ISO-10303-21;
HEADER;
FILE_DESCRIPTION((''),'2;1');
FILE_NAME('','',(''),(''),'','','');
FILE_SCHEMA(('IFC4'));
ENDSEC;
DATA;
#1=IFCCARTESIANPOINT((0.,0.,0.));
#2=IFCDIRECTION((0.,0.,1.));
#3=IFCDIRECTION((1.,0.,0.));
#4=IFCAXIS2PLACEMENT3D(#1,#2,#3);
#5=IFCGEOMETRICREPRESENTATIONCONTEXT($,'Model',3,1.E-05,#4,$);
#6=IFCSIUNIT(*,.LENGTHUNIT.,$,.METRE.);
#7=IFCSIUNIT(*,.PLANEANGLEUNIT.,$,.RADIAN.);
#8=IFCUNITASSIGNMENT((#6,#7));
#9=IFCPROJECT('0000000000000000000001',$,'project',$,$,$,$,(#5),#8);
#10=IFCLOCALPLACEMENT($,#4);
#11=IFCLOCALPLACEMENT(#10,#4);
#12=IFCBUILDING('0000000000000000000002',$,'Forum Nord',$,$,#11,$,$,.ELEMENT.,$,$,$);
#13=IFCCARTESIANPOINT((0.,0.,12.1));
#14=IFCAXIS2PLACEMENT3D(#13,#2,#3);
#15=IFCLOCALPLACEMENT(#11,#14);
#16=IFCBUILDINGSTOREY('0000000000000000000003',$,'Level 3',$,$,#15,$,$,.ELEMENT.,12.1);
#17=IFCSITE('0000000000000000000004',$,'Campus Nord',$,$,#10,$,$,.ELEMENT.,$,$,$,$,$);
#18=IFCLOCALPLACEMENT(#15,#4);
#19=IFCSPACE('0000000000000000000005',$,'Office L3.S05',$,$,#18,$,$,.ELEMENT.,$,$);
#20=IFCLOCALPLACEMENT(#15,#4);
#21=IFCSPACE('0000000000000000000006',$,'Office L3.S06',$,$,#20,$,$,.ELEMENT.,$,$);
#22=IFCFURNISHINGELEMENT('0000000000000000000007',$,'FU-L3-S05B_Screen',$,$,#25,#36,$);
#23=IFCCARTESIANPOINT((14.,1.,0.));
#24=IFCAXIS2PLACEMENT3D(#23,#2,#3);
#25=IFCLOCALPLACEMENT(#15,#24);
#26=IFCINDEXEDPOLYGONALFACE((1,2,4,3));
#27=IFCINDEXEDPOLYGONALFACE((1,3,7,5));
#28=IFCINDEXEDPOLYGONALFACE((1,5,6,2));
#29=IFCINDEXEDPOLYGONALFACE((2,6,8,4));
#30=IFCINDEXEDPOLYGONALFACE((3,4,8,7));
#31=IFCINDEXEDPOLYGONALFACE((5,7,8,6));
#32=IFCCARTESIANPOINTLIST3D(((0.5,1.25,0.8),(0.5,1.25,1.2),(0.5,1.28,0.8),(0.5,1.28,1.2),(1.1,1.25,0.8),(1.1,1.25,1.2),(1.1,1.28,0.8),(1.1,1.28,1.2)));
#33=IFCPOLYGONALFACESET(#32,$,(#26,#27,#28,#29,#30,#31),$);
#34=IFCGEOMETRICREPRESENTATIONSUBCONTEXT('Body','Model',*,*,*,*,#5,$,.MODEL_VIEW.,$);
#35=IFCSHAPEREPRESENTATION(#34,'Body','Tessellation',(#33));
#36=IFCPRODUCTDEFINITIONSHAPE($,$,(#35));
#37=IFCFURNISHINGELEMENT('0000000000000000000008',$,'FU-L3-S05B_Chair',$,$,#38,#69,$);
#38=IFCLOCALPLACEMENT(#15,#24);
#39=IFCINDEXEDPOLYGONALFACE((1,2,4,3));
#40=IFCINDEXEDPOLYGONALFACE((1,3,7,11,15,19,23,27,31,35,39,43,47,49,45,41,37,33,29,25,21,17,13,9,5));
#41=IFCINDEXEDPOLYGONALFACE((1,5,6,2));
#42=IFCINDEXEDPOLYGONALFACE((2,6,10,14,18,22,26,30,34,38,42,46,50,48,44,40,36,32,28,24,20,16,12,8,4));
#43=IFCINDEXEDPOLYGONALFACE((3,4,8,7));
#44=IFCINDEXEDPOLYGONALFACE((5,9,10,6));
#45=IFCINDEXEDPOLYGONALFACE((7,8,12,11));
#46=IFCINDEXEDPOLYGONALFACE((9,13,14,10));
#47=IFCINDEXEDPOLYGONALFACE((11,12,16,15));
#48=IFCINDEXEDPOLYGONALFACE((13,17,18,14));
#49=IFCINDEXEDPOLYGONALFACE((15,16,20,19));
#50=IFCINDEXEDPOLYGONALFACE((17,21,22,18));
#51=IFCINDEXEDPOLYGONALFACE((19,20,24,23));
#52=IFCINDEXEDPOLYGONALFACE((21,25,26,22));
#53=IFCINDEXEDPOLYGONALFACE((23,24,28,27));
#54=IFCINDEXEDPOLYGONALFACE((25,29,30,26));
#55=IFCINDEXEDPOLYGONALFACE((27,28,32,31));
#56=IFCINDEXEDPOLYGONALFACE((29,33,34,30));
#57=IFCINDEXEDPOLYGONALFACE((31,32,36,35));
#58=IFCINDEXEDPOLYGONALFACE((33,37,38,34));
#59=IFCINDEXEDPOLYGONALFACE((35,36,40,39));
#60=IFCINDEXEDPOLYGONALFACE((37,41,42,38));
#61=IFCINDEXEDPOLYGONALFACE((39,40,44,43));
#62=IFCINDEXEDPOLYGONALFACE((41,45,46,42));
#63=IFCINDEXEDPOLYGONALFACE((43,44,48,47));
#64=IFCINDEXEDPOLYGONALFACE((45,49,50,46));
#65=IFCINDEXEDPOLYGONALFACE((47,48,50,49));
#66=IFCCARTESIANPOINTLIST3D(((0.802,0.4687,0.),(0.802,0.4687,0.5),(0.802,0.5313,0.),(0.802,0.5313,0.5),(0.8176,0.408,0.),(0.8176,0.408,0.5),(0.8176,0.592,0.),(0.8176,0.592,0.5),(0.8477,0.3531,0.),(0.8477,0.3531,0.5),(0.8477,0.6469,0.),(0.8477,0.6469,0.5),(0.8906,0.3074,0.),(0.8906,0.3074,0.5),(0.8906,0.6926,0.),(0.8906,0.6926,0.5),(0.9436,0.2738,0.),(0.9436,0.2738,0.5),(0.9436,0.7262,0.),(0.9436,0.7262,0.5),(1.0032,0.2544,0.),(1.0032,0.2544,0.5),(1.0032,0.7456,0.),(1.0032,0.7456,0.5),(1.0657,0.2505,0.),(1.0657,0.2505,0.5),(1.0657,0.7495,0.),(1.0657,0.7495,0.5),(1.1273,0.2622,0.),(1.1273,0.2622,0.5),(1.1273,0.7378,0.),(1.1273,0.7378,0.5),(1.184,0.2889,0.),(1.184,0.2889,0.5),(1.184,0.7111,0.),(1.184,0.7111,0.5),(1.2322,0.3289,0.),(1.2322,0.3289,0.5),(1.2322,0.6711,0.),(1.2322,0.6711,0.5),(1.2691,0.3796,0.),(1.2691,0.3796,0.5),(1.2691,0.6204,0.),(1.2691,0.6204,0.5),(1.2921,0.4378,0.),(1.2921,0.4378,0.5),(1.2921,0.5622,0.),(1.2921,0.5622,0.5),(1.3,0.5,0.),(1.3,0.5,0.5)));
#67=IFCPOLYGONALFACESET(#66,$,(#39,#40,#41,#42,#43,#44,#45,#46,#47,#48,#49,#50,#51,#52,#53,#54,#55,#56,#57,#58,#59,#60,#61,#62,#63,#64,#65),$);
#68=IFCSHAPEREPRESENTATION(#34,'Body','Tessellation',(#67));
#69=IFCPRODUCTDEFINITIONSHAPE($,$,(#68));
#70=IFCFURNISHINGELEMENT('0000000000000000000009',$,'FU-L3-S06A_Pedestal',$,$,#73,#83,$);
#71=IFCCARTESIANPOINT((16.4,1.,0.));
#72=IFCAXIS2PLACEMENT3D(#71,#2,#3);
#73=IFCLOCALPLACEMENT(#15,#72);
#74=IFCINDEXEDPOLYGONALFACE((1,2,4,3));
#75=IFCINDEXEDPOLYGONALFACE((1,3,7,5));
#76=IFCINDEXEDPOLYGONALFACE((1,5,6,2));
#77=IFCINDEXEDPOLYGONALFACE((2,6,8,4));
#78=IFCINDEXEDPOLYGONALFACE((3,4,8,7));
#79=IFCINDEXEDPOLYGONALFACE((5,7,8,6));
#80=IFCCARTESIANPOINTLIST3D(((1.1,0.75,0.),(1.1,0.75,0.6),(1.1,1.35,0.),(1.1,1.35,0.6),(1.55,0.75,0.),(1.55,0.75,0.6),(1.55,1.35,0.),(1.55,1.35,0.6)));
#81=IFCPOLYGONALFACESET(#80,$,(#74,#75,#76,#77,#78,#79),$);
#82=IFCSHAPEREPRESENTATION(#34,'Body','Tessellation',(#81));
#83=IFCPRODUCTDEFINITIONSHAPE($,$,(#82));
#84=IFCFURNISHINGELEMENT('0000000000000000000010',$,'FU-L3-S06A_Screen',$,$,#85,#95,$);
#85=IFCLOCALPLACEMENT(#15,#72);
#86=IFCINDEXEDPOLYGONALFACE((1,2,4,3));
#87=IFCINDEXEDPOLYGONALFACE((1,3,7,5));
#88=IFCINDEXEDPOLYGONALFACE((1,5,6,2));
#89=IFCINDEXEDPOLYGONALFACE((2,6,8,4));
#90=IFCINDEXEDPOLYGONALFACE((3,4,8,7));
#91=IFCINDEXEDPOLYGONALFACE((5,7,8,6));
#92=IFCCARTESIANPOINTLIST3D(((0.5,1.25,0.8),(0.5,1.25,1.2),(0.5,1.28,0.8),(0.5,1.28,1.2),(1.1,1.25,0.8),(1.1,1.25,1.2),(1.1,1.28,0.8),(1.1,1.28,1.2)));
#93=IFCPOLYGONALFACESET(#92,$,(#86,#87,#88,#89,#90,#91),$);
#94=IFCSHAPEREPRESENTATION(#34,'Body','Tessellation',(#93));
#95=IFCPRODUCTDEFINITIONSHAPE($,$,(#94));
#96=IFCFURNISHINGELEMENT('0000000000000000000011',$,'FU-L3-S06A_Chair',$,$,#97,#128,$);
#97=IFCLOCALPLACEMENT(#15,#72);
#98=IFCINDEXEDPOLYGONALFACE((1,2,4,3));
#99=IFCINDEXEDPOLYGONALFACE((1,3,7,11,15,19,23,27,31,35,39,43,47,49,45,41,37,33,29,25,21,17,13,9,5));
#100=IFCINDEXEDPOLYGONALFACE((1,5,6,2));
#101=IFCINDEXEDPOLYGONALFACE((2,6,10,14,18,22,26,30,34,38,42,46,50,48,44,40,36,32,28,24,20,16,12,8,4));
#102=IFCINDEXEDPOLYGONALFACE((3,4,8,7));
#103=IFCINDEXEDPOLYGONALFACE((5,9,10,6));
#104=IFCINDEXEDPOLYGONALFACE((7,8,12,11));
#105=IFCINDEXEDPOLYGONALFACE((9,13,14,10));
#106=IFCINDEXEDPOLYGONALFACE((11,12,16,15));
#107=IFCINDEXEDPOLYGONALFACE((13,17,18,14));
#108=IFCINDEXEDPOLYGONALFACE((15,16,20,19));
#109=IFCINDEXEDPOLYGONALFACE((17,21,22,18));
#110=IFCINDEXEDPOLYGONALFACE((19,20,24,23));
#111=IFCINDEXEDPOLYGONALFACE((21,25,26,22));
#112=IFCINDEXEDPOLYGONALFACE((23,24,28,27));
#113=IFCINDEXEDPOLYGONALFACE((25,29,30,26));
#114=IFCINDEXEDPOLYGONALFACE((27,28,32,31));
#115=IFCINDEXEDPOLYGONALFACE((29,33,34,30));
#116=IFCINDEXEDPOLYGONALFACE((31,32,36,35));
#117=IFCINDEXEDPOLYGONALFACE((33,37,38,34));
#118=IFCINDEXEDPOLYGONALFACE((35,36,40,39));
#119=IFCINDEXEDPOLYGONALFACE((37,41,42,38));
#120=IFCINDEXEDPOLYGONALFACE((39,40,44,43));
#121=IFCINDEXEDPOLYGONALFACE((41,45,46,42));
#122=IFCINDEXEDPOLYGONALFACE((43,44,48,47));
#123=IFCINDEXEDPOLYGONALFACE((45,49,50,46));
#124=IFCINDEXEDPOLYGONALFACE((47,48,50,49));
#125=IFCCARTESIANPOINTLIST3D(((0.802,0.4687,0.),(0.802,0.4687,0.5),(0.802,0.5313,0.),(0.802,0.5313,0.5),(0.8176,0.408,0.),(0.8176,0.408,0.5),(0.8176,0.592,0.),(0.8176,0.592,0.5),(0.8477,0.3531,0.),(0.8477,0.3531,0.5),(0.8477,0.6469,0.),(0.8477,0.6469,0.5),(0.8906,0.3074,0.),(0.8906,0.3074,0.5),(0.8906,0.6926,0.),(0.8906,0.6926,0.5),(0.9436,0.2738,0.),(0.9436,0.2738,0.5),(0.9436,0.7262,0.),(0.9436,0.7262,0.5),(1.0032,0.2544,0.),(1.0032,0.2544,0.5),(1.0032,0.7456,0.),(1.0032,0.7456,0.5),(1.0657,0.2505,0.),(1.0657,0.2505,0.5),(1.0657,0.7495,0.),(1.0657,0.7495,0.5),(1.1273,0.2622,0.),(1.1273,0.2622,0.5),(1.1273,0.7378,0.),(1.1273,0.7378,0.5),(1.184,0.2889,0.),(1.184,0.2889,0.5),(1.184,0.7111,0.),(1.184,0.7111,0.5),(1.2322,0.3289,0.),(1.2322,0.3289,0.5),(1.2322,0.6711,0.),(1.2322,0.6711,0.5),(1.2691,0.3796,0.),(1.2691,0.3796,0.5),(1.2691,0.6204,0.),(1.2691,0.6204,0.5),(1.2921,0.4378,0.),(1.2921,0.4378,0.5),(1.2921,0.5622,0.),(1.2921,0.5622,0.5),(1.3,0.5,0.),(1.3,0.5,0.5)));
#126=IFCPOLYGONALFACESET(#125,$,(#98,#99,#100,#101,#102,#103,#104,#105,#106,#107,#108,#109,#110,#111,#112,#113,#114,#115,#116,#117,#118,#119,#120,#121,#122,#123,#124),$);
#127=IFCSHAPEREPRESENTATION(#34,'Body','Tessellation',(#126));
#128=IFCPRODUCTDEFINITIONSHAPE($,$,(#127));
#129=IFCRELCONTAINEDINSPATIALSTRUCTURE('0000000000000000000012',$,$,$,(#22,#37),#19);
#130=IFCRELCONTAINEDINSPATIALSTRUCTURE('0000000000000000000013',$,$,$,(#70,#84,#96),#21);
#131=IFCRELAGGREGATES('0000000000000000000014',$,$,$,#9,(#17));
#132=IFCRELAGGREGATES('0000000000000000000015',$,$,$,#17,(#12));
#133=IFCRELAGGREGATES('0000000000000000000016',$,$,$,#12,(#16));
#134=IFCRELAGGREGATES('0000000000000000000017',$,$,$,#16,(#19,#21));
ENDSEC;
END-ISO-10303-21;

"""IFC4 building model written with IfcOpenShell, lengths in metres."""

from ifc_helpers import new_model, si_unit, frame, frame_2d, origin_with_axes, place, context, subcontext, project, spatial, rectangle, circle, extrude, element, save


model = new_model("IFC4")

# Units and contexts
model_context = context("Model", 3, precision=1e-05, world=origin_with_axes())
body_context = subcontext(model_context, "Body", "Model", "MODEL_VIEW")
ifc_project = project(units=[si_unit("LENGTHUNIT", "METRE"), si_unit("PLANEANGLEUNIT", "RADIAN")], contexts=[model_context])

# Site, building, storey
site_placement = place(None, origin_with_axes())
site = spatial("IfcSite", under=ifc_project, at=site_placement, Name="Campus Nord", CompositionType="ELEMENT")
building_placement = place(site_placement, origin_with_axes())
building = spatial("IfcBuilding", under=site, at=building_placement, Name="Forum Nord", CompositionType="ELEMENT")
storey_placement = place(building_placement, frame((0.0, 0.0, 12.1), z_axis=(0.0, 0.0, 1.0), x_axis=(1.0, 0.0, 0.0)))
storey = spatial("IfcBuildingStorey", under=building, at=storey_placement, Name="Level 3", CompositionType="ELEMENT", Elevation=12.1)

# Shared definitions
space_1_placement = place(storey_placement, origin_with_axes())
space_1 = spatial("IfcSpace", under=storey, at=space_1_placement, Name="Office L3.S05", CompositionType="ELEMENT")

# Furnishing elements
furnishing_1_placement = place(storey_placement, frame((14.0, 1.0, 0.0), z_axis=(0.0, 0.0, 1.0), x_axis=(1.0, 0.0, 0.0)))
element("IfcFurnishingElement", 1, at=furnishing_1_placement, inside=space_1, Name="FU-L3-S05B_Screen", context=body_context, shape_type="SweptSolid", body=[
    extrude(rectangle(XDim=0.6, YDim=0.03, at=frame_2d((0.8, 1.265), x_axis=(1.0, 0.0))), frame((0.0, 0.0, 0.8), z_axis=(0.0, 0.0, 1.0), x_axis=(1.0, 0.0, 0.0)), (0.0, 0.0, 1.0), 0.4),
])
furnishing_2_placement = place(storey_placement, frame((14.0, 1.0, 0.0), z_axis=(0.0, 0.0, 1.0), x_axis=(1.0, 0.0, 0.0)))
element("IfcFurnishingElement", 2, at=furnishing_2_placement, inside=space_1, Name="FU-L3-S05B_Chair", context=body_context, shape_type="SweptSolid", body=[
    extrude(circle(Radius=0.25, at=frame_2d((1.05, 0.5), x_axis=(1.0, 0.0))), origin_with_axes(), (0.0, 0.0, 1.0), 0.5),
])

# Shared definitions
space_2_placement = place(storey_placement, origin_with_axes())
space_2 = spatial("IfcSpace", under=storey, at=space_2_placement, Name="Office L3.S06", CompositionType="ELEMENT")

# Furnishing elements
furnishing_3_placement = place(storey_placement, frame((16.4, 1.0, 0.0), z_axis=(0.0, 0.0, 1.0), x_axis=(1.0, 0.0, 0.0)))
element("IfcFurnishingElement", 3, at=furnishing_3_placement, inside=space_2, Name="FU-L3-S06A_Pedestal", context=body_context, shape_type="SweptSolid", body=[
    extrude(rectangle(XDim=0.45, YDim=0.6, at=frame_2d((1.325, 1.05), x_axis=(1.0, 0.0))), origin_with_axes(), (0.0, 0.0, 1.0), 0.6),
])
furnishing_4_placement = place(storey_placement, frame((16.4, 1.0, 0.0), z_axis=(0.0, 0.0, 1.0), x_axis=(1.0, 0.0, 0.0)))
element("IfcFurnishingElement", 4, at=furnishing_4_placement, inside=space_2, Name="FU-L3-S06A_Screen", context=body_context, shape_type="SweptSolid", body=[
    extrude(rectangle(XDim=0.6, YDim=0.03, at=frame_2d((0.8, 1.265), x_axis=(1.0, 0.0))), frame((0.0, 0.0, 0.8), z_axis=(0.0, 0.0, 1.0), x_axis=(1.0, 0.0, 0.0)), (0.0, 0.0, 1.0), 0.4),
])
furnishing_5_placement = place(storey_placement, frame((16.4, 1.0, 0.0), z_axis=(0.0, 0.0, 1.0), x_axis=(1.0, 0.0, 0.0)))
element("IfcFurnishingElement", 5, at=furnishing_5_placement, inside=space_2, Name="FU-L3-S06A_Chair", context=body_context, shape_type="SweptSolid", body=[
    extrude(circle(Radius=0.25, at=frame_2d((1.05, 0.5), x_axis=(1.0, 0.0))), origin_with_axes(), (0.0, 0.0, 1.0), 0.5),
])

save(model, "model.ifc")
